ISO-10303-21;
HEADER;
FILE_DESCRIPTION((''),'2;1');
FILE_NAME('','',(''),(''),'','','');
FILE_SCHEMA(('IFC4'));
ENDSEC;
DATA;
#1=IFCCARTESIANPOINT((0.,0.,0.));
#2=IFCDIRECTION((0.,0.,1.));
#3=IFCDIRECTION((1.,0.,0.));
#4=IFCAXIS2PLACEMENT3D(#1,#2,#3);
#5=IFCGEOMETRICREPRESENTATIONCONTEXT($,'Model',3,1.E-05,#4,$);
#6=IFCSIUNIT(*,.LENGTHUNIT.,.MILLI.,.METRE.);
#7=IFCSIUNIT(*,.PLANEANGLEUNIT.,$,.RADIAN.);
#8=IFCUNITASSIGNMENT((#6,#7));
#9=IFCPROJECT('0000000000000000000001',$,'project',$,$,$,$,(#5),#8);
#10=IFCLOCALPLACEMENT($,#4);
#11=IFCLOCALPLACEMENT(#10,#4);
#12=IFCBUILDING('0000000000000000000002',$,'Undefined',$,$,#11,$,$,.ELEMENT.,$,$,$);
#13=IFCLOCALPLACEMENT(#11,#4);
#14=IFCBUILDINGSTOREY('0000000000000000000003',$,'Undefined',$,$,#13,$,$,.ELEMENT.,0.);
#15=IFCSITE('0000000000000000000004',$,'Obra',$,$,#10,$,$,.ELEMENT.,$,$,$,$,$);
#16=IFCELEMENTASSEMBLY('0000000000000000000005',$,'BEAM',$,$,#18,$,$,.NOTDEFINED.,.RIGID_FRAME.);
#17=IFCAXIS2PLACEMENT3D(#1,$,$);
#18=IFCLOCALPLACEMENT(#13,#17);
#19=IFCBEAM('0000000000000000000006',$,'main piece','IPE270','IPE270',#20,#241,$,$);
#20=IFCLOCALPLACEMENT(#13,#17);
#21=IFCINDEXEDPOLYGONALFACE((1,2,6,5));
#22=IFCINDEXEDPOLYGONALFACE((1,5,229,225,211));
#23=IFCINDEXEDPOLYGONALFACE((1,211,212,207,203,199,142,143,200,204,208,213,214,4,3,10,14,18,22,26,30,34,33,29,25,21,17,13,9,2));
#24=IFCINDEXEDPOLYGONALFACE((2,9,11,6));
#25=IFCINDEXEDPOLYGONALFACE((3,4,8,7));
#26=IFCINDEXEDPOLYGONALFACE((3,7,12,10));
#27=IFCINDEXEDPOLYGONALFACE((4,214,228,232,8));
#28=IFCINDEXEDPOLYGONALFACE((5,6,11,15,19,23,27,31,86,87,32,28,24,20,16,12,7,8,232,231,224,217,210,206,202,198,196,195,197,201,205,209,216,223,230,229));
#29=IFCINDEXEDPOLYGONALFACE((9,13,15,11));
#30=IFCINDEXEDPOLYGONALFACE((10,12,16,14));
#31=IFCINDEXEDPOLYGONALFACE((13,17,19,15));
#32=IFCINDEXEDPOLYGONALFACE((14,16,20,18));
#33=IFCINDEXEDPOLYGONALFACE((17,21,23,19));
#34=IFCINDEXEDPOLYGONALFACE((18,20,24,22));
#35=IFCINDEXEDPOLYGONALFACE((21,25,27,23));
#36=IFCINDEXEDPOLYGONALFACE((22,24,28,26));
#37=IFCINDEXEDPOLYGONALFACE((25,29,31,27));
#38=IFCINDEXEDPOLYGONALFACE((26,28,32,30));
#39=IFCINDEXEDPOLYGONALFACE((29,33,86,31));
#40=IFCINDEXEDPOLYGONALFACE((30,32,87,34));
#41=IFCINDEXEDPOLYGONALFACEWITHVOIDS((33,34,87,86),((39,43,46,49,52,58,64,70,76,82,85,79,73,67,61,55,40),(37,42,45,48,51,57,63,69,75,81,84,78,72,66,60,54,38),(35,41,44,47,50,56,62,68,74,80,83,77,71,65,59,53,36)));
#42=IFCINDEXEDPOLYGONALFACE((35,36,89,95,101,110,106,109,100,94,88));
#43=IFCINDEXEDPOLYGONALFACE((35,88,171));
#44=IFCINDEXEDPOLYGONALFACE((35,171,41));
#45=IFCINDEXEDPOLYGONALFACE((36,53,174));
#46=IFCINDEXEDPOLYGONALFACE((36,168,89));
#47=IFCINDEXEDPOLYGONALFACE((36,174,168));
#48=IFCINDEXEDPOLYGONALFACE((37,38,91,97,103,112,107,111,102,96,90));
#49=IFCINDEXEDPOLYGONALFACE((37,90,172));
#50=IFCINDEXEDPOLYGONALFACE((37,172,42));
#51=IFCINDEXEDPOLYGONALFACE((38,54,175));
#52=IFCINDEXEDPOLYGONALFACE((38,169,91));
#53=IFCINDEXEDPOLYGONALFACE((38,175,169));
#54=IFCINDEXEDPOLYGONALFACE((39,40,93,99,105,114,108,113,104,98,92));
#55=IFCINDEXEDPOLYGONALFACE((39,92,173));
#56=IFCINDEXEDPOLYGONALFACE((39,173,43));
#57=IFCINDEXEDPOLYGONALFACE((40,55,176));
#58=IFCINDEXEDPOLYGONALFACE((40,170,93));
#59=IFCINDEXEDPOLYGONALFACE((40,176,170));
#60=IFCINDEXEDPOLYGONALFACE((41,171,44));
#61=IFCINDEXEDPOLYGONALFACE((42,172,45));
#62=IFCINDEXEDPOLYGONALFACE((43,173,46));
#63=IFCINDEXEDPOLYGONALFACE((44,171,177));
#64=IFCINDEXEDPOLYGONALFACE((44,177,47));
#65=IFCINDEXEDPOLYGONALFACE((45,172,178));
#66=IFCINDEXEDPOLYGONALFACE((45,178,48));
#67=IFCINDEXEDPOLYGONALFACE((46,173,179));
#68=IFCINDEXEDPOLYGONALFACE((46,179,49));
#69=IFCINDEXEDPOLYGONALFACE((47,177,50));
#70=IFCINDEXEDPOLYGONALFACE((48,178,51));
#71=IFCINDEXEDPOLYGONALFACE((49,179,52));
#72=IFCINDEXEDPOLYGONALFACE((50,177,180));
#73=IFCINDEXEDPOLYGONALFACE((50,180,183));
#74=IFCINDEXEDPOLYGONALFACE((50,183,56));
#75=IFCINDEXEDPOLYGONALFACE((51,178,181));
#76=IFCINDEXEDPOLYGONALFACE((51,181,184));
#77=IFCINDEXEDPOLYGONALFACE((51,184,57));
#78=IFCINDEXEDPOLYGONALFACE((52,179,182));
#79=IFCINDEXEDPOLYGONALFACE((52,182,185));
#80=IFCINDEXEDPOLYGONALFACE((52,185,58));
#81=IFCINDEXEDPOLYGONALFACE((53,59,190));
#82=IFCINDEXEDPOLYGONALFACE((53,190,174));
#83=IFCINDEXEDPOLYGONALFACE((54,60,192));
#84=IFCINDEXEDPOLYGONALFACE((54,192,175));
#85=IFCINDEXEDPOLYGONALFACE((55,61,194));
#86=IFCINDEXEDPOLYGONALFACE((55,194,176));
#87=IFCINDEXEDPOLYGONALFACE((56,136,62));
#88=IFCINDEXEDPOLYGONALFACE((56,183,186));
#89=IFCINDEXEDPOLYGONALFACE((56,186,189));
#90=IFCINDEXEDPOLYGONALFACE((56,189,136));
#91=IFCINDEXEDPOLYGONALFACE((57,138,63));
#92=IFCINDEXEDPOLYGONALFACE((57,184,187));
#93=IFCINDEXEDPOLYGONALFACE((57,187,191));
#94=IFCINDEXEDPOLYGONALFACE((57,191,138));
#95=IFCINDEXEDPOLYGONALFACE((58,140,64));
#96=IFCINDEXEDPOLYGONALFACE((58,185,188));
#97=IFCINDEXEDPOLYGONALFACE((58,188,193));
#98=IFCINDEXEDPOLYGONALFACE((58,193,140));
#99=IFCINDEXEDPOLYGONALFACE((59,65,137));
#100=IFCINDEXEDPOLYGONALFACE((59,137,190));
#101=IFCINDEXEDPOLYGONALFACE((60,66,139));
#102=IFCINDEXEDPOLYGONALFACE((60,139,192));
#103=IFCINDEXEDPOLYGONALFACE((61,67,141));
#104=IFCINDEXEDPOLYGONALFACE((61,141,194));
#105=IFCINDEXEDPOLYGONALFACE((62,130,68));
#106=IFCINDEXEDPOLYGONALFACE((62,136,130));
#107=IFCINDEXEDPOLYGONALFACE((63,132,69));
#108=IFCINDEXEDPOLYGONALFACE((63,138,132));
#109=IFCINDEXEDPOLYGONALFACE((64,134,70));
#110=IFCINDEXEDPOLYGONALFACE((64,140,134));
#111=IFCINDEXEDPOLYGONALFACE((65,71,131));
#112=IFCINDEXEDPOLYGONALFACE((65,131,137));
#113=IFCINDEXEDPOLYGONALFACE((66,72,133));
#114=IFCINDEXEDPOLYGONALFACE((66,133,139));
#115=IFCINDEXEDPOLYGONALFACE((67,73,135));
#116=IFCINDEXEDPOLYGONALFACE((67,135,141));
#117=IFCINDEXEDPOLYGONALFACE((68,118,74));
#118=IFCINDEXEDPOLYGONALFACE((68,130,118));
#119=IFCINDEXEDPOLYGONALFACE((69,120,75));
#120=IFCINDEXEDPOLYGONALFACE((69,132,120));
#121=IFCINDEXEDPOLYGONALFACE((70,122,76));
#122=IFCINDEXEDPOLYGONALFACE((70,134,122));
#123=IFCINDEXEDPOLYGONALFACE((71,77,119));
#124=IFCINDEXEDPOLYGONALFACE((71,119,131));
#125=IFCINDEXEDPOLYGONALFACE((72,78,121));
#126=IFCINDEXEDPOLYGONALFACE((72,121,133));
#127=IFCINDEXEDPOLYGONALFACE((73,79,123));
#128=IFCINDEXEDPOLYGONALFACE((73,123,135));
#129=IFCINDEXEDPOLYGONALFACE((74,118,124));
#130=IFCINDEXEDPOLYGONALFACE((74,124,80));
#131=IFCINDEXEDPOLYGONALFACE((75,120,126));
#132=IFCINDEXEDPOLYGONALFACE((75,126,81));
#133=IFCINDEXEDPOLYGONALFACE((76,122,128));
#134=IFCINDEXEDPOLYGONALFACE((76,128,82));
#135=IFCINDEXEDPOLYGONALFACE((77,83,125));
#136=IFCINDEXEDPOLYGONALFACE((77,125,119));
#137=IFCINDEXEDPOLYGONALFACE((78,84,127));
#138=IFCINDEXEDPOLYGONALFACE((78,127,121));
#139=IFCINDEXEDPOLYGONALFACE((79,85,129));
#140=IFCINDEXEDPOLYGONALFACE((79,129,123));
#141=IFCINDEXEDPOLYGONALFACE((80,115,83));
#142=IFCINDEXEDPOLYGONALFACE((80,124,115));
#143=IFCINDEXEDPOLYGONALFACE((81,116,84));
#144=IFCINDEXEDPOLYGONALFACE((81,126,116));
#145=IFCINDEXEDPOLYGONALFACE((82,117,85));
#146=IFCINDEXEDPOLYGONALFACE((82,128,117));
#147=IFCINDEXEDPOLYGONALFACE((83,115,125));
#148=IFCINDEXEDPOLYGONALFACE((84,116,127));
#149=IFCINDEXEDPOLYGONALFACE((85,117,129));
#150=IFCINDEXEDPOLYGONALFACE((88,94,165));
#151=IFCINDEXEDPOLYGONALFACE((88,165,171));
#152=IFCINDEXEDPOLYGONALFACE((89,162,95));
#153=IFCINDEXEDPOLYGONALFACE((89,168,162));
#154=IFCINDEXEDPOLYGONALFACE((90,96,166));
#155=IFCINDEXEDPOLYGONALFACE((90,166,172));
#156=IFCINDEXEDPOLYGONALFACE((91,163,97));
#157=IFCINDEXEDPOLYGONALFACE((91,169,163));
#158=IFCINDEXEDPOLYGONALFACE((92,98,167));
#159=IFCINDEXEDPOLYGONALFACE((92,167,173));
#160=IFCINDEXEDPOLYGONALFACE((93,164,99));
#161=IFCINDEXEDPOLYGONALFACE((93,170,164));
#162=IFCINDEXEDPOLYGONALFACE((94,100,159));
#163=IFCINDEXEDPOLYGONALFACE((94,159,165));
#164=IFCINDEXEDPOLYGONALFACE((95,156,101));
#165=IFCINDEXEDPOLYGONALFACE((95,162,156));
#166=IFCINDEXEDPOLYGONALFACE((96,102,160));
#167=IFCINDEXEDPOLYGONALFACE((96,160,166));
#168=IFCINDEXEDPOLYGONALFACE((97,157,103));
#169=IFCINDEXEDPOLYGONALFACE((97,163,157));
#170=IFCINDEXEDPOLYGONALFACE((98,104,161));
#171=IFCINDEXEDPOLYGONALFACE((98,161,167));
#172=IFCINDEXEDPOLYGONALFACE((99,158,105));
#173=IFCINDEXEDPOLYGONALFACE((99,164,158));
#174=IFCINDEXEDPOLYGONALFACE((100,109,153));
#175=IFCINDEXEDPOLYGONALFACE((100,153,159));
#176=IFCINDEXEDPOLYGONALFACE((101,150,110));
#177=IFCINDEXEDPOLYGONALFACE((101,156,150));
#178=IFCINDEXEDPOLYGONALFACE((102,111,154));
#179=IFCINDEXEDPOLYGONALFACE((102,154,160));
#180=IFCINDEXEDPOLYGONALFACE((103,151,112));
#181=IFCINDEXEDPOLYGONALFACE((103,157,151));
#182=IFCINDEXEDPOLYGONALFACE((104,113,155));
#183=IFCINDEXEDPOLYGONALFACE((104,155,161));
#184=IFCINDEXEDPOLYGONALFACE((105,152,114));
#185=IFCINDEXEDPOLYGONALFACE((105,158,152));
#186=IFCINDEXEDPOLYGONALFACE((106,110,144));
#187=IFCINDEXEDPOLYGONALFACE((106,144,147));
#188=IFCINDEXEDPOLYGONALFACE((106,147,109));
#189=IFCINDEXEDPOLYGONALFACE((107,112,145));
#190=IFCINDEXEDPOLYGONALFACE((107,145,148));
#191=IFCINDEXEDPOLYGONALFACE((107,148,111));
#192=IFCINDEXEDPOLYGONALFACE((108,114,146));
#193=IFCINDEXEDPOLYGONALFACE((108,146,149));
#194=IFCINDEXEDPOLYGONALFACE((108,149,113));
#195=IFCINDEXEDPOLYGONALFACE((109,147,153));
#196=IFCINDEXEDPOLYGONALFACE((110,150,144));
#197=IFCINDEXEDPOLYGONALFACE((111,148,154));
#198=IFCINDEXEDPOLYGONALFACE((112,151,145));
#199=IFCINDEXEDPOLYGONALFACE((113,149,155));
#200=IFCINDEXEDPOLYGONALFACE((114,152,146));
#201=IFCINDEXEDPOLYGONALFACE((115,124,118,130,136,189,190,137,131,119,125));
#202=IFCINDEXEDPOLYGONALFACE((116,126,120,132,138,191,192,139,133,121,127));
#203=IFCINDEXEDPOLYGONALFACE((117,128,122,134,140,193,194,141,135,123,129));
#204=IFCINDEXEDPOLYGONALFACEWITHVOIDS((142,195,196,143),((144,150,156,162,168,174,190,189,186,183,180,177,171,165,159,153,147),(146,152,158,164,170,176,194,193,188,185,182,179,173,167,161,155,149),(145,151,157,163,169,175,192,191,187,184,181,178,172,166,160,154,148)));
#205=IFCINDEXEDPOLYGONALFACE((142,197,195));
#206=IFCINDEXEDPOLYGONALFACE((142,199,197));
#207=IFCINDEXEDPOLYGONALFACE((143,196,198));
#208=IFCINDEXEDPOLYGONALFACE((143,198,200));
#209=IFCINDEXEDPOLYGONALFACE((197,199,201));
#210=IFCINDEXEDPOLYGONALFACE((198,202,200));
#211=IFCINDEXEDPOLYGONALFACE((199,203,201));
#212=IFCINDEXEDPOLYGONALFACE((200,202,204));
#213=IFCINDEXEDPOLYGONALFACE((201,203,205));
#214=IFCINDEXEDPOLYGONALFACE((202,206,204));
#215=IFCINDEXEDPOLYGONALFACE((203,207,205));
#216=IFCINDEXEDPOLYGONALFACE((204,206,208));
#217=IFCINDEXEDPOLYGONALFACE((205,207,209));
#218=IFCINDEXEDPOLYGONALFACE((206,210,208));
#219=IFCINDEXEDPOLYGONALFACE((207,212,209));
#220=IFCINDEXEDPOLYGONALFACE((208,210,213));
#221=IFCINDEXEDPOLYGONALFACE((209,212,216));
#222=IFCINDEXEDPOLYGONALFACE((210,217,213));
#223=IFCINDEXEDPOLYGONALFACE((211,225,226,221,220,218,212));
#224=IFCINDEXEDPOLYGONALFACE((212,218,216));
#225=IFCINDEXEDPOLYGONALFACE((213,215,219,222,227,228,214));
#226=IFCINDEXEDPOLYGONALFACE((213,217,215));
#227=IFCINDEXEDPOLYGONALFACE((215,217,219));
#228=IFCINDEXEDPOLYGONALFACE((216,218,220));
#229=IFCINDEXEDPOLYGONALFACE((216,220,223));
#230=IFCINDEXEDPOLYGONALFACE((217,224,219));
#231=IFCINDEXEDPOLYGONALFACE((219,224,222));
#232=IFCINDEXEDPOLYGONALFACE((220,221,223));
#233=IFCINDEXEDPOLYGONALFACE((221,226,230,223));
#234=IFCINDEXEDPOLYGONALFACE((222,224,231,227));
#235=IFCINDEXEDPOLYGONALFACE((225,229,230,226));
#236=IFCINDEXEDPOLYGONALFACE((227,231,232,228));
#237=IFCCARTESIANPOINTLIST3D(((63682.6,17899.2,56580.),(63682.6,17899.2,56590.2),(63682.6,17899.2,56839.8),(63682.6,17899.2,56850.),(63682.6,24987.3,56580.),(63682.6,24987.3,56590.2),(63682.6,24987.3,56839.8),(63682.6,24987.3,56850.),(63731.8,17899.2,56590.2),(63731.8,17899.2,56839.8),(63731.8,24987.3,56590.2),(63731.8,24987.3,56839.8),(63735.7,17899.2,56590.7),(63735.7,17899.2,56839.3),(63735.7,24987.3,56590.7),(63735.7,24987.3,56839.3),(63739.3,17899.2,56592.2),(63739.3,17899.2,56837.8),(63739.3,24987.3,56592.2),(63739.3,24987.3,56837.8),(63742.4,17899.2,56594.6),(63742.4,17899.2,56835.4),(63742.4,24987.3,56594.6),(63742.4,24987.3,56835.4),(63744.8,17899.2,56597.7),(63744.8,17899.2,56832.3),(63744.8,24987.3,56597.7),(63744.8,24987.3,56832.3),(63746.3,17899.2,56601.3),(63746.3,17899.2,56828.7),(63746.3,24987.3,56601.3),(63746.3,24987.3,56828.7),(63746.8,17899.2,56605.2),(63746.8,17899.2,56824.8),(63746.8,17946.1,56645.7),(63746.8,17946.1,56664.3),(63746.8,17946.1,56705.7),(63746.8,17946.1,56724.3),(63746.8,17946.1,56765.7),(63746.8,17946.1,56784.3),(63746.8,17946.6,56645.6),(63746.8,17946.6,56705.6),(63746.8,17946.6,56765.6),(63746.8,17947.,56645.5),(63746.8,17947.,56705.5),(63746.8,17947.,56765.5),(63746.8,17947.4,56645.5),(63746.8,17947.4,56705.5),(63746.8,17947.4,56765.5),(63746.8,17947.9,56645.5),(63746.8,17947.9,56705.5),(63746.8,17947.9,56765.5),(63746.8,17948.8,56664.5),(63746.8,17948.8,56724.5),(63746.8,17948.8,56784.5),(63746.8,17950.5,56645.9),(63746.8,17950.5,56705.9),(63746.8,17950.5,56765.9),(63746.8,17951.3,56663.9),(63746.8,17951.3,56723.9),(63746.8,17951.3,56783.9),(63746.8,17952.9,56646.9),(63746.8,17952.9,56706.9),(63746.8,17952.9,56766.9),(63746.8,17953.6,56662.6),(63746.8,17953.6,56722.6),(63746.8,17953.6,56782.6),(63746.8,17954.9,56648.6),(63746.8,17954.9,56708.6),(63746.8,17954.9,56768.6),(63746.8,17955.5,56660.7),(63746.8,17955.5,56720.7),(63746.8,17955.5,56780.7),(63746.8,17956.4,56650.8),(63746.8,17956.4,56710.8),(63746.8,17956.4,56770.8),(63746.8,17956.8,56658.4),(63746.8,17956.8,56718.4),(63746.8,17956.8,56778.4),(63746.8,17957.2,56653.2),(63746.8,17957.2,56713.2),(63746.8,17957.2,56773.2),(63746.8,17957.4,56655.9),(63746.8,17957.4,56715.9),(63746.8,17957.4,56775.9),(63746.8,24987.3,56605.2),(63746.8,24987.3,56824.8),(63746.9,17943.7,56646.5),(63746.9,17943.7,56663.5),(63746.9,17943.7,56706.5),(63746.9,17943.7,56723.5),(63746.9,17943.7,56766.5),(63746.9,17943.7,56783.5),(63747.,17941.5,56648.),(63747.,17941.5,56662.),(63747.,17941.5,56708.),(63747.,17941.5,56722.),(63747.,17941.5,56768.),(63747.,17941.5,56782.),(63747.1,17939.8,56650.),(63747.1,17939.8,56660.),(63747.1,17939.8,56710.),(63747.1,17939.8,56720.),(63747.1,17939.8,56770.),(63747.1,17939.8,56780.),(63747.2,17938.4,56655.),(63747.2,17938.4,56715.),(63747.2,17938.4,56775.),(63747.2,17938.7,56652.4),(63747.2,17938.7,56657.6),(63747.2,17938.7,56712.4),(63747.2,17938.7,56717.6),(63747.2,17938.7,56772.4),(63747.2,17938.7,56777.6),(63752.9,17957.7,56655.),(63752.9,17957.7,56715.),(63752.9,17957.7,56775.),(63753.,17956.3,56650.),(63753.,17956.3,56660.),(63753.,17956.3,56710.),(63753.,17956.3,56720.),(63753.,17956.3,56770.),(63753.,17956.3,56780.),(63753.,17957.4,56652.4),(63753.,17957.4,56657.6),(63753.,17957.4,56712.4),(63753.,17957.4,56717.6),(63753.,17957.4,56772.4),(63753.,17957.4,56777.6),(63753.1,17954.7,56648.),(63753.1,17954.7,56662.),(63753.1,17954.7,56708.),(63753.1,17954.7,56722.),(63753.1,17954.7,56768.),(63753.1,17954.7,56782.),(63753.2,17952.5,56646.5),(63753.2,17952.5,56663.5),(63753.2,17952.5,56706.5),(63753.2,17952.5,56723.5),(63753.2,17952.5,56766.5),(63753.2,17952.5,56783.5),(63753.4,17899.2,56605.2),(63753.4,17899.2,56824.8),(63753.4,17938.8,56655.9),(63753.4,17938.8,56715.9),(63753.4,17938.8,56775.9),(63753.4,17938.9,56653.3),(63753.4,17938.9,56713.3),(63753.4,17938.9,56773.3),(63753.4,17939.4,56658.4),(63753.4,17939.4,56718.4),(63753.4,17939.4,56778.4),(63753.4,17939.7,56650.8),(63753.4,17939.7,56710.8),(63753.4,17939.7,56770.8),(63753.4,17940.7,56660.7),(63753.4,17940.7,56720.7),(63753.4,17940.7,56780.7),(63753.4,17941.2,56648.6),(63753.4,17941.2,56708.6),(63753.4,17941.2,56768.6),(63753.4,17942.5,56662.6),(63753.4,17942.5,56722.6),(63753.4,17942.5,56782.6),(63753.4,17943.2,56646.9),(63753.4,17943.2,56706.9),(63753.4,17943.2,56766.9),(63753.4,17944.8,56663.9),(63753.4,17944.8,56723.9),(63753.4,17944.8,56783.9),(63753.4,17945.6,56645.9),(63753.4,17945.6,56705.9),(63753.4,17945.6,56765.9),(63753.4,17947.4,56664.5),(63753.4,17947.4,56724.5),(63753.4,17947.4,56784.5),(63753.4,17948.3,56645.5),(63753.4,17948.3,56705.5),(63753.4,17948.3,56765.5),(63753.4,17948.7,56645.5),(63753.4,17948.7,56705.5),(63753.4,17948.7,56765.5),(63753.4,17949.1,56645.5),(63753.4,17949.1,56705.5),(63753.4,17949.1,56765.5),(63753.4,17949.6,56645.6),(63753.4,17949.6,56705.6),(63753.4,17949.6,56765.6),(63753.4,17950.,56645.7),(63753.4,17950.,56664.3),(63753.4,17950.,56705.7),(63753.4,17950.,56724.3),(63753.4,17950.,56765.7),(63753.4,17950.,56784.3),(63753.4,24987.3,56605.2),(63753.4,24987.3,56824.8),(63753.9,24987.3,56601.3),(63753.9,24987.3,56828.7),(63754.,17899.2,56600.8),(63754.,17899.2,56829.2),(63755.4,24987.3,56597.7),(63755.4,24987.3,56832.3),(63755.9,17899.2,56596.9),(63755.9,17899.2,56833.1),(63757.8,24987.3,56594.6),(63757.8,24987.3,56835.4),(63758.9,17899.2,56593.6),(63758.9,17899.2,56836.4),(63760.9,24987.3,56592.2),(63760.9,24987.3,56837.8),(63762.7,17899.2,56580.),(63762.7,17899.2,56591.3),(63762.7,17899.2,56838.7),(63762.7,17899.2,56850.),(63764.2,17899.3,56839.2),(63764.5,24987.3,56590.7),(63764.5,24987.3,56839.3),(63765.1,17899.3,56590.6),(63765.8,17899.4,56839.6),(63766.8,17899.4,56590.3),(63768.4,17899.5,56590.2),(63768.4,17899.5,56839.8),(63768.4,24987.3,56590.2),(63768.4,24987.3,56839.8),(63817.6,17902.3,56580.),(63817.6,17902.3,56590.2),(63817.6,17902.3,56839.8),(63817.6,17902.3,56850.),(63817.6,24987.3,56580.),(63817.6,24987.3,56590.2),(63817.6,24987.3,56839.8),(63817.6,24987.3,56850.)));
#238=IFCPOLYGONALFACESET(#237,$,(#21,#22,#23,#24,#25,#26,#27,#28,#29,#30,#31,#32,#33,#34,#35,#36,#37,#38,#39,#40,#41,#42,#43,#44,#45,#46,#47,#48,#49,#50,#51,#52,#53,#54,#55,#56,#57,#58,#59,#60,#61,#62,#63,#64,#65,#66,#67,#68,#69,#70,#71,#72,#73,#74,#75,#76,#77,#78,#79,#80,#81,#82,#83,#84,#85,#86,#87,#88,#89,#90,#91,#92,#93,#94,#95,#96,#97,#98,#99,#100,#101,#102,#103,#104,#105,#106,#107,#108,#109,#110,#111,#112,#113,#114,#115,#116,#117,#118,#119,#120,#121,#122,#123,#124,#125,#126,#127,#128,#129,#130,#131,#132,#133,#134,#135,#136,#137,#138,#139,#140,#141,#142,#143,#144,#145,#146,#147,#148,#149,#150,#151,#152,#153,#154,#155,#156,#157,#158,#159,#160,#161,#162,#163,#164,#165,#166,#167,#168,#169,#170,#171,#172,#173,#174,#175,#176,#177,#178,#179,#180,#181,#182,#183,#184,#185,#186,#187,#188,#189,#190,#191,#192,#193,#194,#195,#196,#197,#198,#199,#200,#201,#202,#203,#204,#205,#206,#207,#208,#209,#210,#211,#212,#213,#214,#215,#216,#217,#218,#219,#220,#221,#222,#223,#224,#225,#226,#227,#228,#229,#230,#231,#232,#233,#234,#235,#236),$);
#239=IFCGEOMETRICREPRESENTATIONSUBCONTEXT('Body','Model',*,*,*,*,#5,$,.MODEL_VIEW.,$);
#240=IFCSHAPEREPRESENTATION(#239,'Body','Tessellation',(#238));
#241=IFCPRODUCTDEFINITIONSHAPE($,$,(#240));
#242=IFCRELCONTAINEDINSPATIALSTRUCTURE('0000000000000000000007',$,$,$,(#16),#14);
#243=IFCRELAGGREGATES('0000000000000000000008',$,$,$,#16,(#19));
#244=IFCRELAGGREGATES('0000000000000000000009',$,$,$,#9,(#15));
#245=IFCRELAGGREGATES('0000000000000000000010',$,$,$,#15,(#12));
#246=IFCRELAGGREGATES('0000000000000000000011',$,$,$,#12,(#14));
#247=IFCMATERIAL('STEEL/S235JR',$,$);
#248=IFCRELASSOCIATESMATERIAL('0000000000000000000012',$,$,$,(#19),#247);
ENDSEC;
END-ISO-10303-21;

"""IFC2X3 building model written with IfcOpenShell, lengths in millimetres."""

from ifc_helpers import new_model, si_unit, frame, origin_with_axes, origin_2d_with_axis, place, context, subcontext, project, spatial, circle, i_section, extrude, clip, halfspace, source, transform, mapped, material, element, aggregate, save


model = new_model("IFC2X3")

# Units and contexts
model_context = context("Model", 3, precision=1e-05, world=origin_with_axes())
body_context = subcontext(model_context, "Body", "Model", "MODEL_VIEW")
ifc_project = project(units=[si_unit("LENGTHUNIT", "METRE", prefix="MILLI"), si_unit("PLANEANGLEUNIT", "RADIAN")], contexts=[model_context])

# Site, building, storey
site_placement = place(None, origin_with_axes())
site = spatial("IfcSite", under=ifc_project, at=site_placement, Name="Obra", CompositionType="ELEMENT")
building_placement = place(site_placement, origin_with_axes())
building = spatial("IfcBuilding", under=site, at=building_placement, Name="Undefined", CompositionType="ELEMENT")
storey_placement = place(building_placement, origin_with_axes())
storey = spatial("IfcBuildingStorey", under=building, at=storey_placement, Name="Undefined", CompositionType="ELEMENT", Elevation=0.0)

# Shared definitions
ifc_material_1 = material(Name="STEEL/S235JR")

# Element assembly, beam, opening
assembly_1_placement = place(storey_placement, origin_with_axes())
assembly_1 = element("IfcElementAssembly", 1, at=assembly_1_placement, inside=storey, Name="BEAM", AssemblyPlace="NOTDEFINED", PredefinedType="RIGID_FRAME")
beam_1_placement = place(assembly_1_placement, frame((63750.1, 17899.2, 56715.0), z_axis=(0.0, 0.0, 1.0), x_axis=(0.0, 1.0, 0.0)))
beam_1 = element("IfcBeam", 2, at=beam_1_placement, material=ifc_material_1, Name="main piece", Description="IPE270", ObjectType="IPE270", context=body_context, shape_type="Clipping", body=[
    clip(extrude(i_section(OverallWidth=135.0, OverallDepth=270.0, WebThickness=6.6, FlangeThickness=10.2, FilletRadius=15.0, at=origin_2d_with_axis()), frame((7088.1, 0.0, 0.0), z_axis=(-1.0, 0.0, 0.0), x_axis=(0.0, -1.0, 0.0)), (0.0, 0.0, 1.0), 7088.1), halfspace(frame((-5.8, 89.1, -120.0), z_axis=(-0.998367, -0.057127, 0.0), x_axis=(0.0, 0.0, 1.0)), False)),
])
shared_shape_1 = source(origin_with_axes(), body_context, "Body", "SweptSolid", [
    extrude(circle(Radius=9.5, at=origin_2d_with_axis()), frame((0.0, -35.4, 0.0), z_axis=(0.0, 1.0, 0.0), x_axis=(1.0, 0.0, 0.0)), (0.0, 0.0, 1.0), 6.8),
])
opening_1_placement = place(assembly_1_placement, frame((63721.0, 17896.3, 56835.0), z_axis=(-0.057107, 0.998368, 0.0), x_axis=(0.0, 0.0, -1.0)))
element("IfcOpeningElement", 3, at=opening_1_placement, cuts=beam_1, ObjectType="Opening", context=body_context, shape_type="MappedRepresentation", body=[
    mapped(shared_shape_1, transform((60.0, 0.0, 50.0))),
    mapped(shared_shape_1, transform((120.0, 0.0, 50.0))),
    mapped(shared_shape_1, transform((180.0, 0.0, 50.0))),
])
aggregate(assembly_1, [beam_1])

save(model, "model.ifc")
